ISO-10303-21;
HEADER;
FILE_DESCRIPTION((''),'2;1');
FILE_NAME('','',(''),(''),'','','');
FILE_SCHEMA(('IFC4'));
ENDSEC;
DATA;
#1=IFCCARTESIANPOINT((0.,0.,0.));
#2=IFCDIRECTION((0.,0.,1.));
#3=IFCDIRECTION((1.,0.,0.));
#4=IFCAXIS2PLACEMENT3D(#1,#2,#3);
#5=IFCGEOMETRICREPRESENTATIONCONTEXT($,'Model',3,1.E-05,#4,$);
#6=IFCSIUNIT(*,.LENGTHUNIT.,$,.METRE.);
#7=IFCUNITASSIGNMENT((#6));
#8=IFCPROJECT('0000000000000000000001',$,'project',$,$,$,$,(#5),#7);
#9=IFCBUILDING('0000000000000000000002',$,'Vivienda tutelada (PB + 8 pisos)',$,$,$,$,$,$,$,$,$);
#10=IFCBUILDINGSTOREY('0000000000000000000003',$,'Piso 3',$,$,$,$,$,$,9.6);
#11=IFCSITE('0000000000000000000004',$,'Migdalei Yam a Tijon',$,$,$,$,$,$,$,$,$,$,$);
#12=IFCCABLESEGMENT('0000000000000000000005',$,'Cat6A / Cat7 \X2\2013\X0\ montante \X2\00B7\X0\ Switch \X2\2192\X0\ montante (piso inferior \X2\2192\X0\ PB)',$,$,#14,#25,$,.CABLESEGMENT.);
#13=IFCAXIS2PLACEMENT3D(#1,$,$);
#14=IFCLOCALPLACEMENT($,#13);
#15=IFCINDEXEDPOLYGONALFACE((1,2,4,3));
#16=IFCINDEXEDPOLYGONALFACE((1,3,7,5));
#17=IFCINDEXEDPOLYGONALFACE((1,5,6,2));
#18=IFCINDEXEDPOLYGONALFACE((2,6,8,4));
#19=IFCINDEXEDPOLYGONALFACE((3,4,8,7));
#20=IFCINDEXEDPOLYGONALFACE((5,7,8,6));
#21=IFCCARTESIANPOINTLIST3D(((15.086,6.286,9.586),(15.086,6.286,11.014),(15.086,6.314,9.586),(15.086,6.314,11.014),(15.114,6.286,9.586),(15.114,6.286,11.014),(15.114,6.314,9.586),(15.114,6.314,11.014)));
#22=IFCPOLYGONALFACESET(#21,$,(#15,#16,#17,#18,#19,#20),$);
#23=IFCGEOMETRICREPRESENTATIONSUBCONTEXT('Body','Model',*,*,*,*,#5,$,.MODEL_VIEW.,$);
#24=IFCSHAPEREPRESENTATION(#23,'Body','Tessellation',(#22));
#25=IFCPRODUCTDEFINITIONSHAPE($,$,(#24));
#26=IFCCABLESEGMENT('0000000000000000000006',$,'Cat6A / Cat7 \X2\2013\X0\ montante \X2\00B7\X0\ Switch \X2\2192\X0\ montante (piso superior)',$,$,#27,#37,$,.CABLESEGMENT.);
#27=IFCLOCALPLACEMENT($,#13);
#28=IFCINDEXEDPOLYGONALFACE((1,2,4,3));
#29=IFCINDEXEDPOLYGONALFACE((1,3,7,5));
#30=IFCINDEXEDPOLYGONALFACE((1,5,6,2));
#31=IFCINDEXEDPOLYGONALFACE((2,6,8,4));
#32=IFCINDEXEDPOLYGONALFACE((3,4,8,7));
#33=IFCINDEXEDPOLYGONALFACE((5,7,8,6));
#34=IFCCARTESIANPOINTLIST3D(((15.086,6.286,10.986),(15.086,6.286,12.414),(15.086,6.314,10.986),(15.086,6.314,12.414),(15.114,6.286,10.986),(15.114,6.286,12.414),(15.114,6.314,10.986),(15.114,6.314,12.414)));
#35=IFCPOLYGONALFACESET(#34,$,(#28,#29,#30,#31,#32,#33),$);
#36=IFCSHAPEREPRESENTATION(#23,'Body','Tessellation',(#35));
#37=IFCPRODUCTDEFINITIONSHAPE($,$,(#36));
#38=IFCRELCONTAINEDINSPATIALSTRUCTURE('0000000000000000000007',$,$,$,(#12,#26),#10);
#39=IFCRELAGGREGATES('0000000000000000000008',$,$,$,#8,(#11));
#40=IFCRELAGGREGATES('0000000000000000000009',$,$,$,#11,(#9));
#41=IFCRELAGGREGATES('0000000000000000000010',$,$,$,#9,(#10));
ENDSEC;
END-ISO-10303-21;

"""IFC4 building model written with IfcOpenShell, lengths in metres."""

from ifc_helpers import new_model, si_unit, frame, origin_with_axes, context, subcontext, project, spatial, line, indexed_curve, outline, extrude, element, save


model = new_model("IFC4")

# Units and contexts
model_context = context("Model", 3, precision=1e-05, world=origin_with_axes())
body_context = subcontext(model_context, "Body", "Model", "MODEL_VIEW")
ifc_project = project(units=[si_unit("LENGTHUNIT", "METRE")], contexts=[model_context])

# Site, building, storey
site = spatial("IfcSite", under=ifc_project, Name="Migdalei Yam a Tijon")
building = spatial("IfcBuilding", under=site, Name="Vivienda tutelada (PB + 8 pisos)")
storey = spatial("IfcBuildingStorey", under=building, Name="Piso 3", Elevation=9.6)

# Cable segments
element("IfcCableSegment", 1, inside=storey, Name="Cat6A / Cat7 – montante · Switch → montante (piso inferior → PB)", PredefinedType="CABLESEGMENT", context=body_context, shape_type="SweptSolid", body=[
    extrude(outline(indexed_curve([(0.0, 0.0), (0.028, 0.0), (0.028, 0.028), (0.0, 0.028)], segments=[line(1, 2, 3, 4, 1)])), frame((15.086, 6.286, 9.586), z_axis=(0.0, 0.0, 1.0), x_axis=(1.0, 0.0, 0.0)), (0.0, 0.0, 1.0), 1.428),
])
element("IfcCableSegment", 2, inside=storey, Name="Cat6A / Cat7 – montante · Switch → montante (piso superior)", PredefinedType="CABLESEGMENT", context=body_context, shape_type="SweptSolid", body=[
    extrude(outline(indexed_curve([(0.0, 0.0), (0.028, 0.0), (0.028, 0.028), (0.0, 0.028)], segments=[line(1, 2, 3, 4, 1)])), frame((15.086, 6.286, 10.986), z_axis=(0.0, 0.0, 1.0), x_axis=(1.0, 0.0, 0.0)), (0.0, 0.0, 1.0), 1.428),
])

save(model, "model.ifc")
